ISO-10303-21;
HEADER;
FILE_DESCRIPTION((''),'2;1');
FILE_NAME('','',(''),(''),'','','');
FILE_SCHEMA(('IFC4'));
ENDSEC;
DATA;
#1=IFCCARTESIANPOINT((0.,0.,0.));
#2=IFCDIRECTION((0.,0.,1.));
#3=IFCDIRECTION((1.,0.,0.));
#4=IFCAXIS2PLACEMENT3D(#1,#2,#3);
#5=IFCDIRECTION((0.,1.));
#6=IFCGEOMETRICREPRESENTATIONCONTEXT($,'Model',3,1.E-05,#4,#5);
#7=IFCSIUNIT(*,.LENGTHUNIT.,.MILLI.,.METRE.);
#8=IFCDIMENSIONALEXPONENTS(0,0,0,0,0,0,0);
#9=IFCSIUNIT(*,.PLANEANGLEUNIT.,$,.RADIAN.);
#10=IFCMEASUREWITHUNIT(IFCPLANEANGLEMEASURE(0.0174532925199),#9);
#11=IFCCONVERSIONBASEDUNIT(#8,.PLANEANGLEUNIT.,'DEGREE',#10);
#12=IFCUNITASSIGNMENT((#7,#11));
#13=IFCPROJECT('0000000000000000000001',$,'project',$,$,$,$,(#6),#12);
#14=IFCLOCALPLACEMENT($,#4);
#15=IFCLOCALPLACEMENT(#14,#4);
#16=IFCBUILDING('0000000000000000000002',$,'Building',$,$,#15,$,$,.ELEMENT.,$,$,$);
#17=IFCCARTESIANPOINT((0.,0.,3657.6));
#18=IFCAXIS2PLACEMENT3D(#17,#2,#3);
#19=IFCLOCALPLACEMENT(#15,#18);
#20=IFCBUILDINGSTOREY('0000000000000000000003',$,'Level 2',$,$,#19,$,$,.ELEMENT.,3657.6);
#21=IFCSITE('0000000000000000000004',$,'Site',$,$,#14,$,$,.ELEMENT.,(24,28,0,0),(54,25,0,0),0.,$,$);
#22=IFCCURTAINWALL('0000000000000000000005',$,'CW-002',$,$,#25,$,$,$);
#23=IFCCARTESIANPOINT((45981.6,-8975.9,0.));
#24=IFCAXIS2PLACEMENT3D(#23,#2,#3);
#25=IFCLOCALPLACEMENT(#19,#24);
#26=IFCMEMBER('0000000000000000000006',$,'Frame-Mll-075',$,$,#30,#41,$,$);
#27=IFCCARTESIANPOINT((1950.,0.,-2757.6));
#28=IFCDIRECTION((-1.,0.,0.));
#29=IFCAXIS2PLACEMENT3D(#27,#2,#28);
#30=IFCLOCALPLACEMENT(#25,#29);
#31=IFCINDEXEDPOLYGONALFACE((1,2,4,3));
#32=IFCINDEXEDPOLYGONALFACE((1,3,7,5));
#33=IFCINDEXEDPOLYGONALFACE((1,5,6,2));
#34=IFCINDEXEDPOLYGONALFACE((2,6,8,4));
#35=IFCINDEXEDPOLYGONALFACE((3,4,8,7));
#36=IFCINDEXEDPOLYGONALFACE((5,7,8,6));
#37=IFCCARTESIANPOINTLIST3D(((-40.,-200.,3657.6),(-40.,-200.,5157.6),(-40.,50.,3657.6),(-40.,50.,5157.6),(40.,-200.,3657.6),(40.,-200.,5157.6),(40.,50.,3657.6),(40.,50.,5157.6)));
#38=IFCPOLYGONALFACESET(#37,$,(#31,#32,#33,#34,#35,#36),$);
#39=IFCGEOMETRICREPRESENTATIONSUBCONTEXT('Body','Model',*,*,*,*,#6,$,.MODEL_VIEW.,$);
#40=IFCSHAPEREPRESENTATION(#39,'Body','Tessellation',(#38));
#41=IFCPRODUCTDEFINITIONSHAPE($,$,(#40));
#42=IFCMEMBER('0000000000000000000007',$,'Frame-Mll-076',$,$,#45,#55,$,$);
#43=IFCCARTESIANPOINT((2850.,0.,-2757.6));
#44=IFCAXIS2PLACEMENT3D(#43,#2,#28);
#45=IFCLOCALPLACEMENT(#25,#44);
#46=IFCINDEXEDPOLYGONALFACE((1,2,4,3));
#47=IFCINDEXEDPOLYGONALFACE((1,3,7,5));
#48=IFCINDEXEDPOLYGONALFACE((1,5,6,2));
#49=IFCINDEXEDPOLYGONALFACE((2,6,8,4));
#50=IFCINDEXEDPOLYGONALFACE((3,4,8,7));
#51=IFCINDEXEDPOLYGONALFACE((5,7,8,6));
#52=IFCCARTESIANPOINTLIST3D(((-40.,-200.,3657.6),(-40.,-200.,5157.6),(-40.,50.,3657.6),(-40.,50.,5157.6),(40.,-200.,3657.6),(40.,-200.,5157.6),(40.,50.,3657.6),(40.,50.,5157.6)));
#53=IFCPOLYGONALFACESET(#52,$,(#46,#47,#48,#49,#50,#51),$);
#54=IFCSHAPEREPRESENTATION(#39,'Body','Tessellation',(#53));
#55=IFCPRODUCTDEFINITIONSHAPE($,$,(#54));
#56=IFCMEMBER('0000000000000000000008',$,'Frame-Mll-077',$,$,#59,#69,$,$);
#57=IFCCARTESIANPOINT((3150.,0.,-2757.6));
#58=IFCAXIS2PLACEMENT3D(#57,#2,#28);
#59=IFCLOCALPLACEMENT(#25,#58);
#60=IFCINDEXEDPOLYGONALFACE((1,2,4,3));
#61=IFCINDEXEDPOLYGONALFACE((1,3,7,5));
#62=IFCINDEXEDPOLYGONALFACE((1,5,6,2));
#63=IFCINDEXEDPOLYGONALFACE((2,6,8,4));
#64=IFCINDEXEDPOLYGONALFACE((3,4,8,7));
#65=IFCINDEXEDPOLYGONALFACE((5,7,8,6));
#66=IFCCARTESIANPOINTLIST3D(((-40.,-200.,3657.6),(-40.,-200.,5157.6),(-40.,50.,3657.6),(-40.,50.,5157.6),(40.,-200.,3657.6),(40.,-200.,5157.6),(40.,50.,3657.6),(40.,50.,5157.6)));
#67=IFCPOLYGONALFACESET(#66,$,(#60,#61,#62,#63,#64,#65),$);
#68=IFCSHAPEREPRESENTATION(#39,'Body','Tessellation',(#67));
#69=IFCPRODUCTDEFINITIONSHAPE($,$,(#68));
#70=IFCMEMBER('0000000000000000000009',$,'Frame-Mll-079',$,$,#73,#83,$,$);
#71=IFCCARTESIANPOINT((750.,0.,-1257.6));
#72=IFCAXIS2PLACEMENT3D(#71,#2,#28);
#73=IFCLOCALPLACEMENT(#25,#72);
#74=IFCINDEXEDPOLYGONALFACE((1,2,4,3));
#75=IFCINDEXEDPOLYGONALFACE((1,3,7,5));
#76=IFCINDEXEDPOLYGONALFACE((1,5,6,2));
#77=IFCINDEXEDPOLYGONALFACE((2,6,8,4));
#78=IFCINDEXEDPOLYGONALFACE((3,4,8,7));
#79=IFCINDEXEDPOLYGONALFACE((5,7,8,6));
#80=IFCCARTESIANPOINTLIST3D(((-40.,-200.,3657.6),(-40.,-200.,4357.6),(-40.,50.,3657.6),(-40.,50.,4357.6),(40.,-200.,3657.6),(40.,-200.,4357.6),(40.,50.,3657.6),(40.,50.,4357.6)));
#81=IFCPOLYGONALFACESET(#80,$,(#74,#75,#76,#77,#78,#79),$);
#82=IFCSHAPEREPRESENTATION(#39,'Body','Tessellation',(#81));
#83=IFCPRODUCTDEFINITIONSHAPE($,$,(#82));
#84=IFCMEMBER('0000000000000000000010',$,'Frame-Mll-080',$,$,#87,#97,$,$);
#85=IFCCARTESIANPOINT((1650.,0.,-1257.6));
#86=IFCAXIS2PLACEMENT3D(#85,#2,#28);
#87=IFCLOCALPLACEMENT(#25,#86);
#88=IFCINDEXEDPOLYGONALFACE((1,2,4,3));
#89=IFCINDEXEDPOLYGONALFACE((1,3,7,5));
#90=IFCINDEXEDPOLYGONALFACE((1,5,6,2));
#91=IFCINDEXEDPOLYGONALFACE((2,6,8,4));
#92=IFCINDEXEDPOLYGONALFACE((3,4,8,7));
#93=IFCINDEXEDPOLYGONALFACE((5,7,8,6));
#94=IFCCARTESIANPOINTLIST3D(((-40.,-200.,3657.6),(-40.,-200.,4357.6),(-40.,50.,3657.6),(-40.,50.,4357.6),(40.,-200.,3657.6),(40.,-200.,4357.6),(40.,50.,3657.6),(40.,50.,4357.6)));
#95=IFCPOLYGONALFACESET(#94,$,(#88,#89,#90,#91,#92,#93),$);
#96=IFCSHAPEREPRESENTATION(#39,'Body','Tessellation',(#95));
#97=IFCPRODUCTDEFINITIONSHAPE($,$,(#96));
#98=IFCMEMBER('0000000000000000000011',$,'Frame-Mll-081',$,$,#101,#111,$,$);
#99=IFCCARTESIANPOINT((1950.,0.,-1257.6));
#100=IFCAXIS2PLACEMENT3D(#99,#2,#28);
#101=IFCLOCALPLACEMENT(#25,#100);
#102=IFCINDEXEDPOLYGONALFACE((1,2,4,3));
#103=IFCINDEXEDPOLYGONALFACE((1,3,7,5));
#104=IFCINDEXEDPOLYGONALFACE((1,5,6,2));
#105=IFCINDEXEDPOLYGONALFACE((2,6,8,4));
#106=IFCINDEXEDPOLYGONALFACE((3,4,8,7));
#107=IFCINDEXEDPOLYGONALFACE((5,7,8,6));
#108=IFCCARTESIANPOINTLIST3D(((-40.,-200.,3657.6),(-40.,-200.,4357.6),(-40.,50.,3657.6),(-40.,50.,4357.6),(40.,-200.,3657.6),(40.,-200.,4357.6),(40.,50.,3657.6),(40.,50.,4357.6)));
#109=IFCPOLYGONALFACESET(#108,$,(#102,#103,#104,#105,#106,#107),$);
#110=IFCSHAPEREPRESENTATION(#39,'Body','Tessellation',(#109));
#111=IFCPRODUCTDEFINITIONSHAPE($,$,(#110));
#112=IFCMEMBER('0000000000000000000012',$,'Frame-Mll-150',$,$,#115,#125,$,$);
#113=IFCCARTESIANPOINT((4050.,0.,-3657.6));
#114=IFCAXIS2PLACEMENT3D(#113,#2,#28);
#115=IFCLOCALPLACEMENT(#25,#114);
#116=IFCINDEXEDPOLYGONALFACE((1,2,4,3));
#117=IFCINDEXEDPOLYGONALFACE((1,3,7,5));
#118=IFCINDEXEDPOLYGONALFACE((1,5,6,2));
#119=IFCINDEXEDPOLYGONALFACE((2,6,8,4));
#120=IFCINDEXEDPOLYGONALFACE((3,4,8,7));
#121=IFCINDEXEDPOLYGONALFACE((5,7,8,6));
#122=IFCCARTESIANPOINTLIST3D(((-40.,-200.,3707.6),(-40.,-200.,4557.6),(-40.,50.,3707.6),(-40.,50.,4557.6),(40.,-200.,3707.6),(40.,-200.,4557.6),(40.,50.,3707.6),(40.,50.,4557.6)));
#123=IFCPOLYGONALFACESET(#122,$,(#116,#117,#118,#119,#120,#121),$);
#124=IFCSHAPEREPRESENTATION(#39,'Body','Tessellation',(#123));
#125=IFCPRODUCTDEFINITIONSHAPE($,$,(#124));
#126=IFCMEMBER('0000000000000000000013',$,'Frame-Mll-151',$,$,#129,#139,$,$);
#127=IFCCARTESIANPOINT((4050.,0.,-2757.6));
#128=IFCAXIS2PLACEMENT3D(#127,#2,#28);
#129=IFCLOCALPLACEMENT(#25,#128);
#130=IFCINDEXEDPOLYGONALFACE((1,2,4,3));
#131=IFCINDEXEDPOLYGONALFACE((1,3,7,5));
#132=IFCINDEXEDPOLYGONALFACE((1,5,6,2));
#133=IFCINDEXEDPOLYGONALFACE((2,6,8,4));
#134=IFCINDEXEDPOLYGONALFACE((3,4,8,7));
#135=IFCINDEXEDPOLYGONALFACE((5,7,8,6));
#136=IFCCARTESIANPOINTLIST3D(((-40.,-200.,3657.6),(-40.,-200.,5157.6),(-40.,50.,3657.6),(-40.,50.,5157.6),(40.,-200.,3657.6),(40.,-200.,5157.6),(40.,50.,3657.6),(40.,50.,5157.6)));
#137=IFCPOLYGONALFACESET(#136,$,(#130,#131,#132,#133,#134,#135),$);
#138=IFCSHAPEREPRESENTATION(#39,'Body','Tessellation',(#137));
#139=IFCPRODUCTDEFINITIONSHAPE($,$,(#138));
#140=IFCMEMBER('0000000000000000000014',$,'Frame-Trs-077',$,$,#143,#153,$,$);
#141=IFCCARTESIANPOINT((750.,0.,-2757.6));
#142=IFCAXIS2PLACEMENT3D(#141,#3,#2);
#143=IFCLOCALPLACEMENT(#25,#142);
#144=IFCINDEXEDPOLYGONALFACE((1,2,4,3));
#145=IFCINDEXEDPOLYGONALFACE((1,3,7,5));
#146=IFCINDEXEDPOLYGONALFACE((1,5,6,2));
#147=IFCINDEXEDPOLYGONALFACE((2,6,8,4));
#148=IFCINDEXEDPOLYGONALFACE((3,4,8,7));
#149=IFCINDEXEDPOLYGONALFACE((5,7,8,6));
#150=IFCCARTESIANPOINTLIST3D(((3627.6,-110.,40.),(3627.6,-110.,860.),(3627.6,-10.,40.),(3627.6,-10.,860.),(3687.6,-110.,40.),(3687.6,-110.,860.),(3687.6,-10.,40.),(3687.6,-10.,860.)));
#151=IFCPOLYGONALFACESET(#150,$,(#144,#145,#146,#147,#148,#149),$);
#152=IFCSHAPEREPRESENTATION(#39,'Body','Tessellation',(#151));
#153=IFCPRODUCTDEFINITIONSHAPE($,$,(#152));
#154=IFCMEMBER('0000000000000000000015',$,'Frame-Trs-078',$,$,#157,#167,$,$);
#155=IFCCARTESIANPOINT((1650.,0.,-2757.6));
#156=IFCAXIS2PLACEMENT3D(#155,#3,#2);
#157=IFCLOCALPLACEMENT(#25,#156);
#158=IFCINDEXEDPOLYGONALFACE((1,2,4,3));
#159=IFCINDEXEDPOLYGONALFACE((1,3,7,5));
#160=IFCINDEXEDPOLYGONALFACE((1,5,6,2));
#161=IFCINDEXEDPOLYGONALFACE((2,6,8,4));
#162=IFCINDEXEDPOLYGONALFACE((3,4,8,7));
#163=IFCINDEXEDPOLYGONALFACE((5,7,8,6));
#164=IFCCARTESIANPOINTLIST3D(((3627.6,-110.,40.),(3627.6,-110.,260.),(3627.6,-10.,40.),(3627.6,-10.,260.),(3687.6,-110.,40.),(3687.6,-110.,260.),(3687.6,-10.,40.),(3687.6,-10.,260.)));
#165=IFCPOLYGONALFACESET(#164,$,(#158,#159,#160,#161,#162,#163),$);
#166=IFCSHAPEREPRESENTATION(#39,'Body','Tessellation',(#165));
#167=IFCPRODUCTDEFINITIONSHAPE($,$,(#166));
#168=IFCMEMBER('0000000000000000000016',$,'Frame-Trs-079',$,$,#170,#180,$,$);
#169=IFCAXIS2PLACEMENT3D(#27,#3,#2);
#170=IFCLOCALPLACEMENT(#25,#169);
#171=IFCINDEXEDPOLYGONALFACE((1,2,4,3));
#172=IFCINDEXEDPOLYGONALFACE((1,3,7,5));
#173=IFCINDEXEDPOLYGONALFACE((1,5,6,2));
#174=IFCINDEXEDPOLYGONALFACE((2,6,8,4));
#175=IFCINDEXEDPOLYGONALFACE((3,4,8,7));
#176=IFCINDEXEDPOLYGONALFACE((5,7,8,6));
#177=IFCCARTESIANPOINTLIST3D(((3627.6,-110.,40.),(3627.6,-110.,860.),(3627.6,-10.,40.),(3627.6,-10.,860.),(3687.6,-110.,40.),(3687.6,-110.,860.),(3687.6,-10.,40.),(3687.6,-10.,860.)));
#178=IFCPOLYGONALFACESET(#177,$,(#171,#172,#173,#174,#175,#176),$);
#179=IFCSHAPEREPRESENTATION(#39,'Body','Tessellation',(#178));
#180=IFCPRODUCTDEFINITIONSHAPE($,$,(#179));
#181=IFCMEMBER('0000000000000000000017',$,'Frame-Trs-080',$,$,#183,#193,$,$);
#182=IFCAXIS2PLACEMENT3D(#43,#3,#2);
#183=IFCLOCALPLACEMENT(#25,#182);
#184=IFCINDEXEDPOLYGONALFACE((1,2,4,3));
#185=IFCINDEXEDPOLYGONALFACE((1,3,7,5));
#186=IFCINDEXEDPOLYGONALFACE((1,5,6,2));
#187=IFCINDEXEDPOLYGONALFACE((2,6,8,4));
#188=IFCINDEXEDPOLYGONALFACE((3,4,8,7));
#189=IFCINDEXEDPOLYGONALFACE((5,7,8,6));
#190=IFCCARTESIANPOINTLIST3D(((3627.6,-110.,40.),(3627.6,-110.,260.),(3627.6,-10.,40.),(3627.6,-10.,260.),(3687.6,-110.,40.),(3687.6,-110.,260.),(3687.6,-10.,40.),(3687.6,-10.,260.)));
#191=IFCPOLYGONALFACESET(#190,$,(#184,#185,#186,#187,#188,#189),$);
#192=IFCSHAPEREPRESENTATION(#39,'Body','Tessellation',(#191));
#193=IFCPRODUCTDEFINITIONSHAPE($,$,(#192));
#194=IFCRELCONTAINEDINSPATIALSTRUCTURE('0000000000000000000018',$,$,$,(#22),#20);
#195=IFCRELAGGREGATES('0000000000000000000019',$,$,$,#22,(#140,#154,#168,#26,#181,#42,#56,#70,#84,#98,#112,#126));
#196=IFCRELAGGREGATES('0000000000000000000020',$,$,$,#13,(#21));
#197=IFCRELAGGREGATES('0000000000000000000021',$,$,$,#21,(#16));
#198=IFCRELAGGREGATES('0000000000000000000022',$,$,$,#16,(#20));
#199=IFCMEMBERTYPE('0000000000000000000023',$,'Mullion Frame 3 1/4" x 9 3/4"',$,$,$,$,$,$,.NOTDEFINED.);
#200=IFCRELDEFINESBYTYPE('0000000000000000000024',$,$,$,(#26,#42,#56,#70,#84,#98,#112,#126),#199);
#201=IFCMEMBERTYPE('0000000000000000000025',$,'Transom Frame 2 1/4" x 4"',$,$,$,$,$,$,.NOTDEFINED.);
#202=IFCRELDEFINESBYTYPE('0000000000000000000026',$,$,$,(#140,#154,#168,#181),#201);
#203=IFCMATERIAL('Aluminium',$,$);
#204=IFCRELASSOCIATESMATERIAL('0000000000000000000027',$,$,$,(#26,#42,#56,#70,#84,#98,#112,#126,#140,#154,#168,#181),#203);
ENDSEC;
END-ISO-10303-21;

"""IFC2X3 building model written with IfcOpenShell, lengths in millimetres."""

from ifc_helpers import new_model, entity, si_unit, converted_unit, direction, frame, origin_with_axes, place, context, subcontext, project, spatial, polyline, outline, extrude, material, type_object, element, aggregate, save


model = new_model("IFC2X3")

# Units and contexts
model_context = context("Model", 3, precision=1e-05, world=origin_with_axes(), true_north=direction((0.0, 1.0)))
body_context = subcontext(model_context, "Body", "Model", "MODEL_VIEW")
ifc_project = project(units=[si_unit("LENGTHUNIT", "METRE", prefix="MILLI"), converted_unit("PLANEANGLEUNIT", "DEGREE", entity("IfcPlaneAngleMeasure", 0.0174532925199), si_unit("PLANEANGLEUNIT", "RADIAN"), dimensions=[0, 0, 0, 0, 0, 0, 0])], contexts=[model_context])

# Site, building, storey
site_placement = place(None, origin_with_axes())
site = spatial("IfcSite", under=ifc_project, at=site_placement, Name="Site", CompositionType="ELEMENT", RefLatitude=(24, 28, 0, 0), RefLongitude=(54, 25, 0, 0), RefElevation=0.0)
building_placement = place(site_placement, origin_with_axes())
building = spatial("IfcBuilding", under=site, at=building_placement, Name="Building", CompositionType="ELEMENT")
storey_placement = place(building_placement, frame((0.0, 0.0, 3657.6), z_axis=(0.0, 0.0, 1.0), x_axis=(1.0, 0.0, 0.0)))
storey = spatial("IfcBuildingStorey", under=building, at=storey_placement, Name="Level 2", CompositionType="ELEMENT", Elevation=3657.6)

# Curtain wall, members
curtain_wall_placement = place(storey_placement, frame((45981.6, -8975.9, 0.0), z_axis=(0.0, 0.0, 1.0), x_axis=(1.0, 0.0, 0.0)))
curtain_wall = element("IfcCurtainWall", 1, at=curtain_wall_placement, inside=storey, Name="CW-002")
ifc_material_1 = material(Name="Aluminium")
member_type_1 = type_object("IfcMemberType", Name="Mullion Frame 3 1/4\" x 9 3/4\"", PredefinedType="NOTDEFINED")
member_1_placement = place(curtain_wall_placement, frame((1950.0, 0.0, -2757.6), z_axis=(0.0, 0.0, 1.0), x_axis=(-1.0, 0.0, 0.0)))
member_1 = element("IfcMember", 2, at=member_1_placement, type_object=member_type_1, material=ifc_material_1, Name="Frame-Mll-075", context=body_context, shape_type="SweptSolid", body=[
    extrude(outline(polyline([(-40.0, 200.0), (-40.0, -50.0), (40.0, -50.0), (40.0, 200.0), (-40.0, 200.0)])), frame((0.0, 0.0, 3657.6), z_axis=(0.0, 0.0, 1.0), x_axis=(-1.0, 0.0, 0.0)), (0.0, 0.0, 1.0), 1500.0),
])
member_2_placement = place(curtain_wall_placement, frame((2850.0, 0.0, -2757.6), z_axis=(0.0, 0.0, 1.0), x_axis=(-1.0, 0.0, 0.0)))
member_2 = element("IfcMember", 3, at=member_2_placement, type_object=member_type_1, material=ifc_material_1, Name="Frame-Mll-076", context=body_context, shape_type="SweptSolid", body=[
    extrude(outline(polyline([(-40.0, 200.0), (-40.0, -50.0), (40.0, -50.0), (40.0, 200.0), (-40.0, 200.0)])), frame((0.0, 0.0, 3657.6), z_axis=(0.0, 0.0, 1.0), x_axis=(-1.0, 0.0, 0.0)), (0.0, 0.0, 1.0), 1500.0),
])
member_3_placement = place(curtain_wall_placement, frame((3150.0, 0.0, -2757.6), z_axis=(0.0, 0.0, 1.0), x_axis=(-1.0, 0.0, 0.0)))
member_3 = element("IfcMember", 4, at=member_3_placement, type_object=member_type_1, material=ifc_material_1, Name="Frame-Mll-077", context=body_context, shape_type="SweptSolid", body=[
    extrude(outline(polyline([(-40.0, 200.0), (-40.0, -50.0), (40.0, -50.0), (40.0, 200.0), (-40.0, 200.0)])), frame((0.0, 0.0, 3657.6), z_axis=(0.0, 0.0, 1.0), x_axis=(-1.0, 0.0, 0.0)), (0.0, 0.0, 1.0), 1500.0),
])
member_4_placement = place(curtain_wall_placement, frame((750.0, 0.0, -1257.6), z_axis=(0.0, 0.0, 1.0), x_axis=(-1.0, 0.0, 0.0)))
member_4 = element("IfcMember", 5, at=member_4_placement, type_object=member_type_1, material=ifc_material_1, Name="Frame-Mll-079", context=body_context, shape_type="SweptSolid", body=[
    extrude(outline(polyline([(-40.0, 200.0), (-40.0, -50.0), (40.0, -50.0), (40.0, 200.0), (-40.0, 200.0)])), frame((0.0, 0.0, 3657.6), z_axis=(0.0, 0.0, 1.0), x_axis=(-1.0, 0.0, 0.0)), (0.0, 0.0, 1.0), 700.0),
])
member_5_placement = place(curtain_wall_placement, frame((1650.0, 0.0, -1257.6), z_axis=(0.0, 0.0, 1.0), x_axis=(-1.0, 0.0, 0.0)))
member_5 = element("IfcMember", 6, at=member_5_placement, type_object=member_type_1, material=ifc_material_1, Name="Frame-Mll-080", context=body_context, shape_type="SweptSolid", body=[
    extrude(outline(polyline([(-40.0, 200.0), (-40.0, -50.0), (40.0, -50.0), (40.0, 200.0), (-40.0, 200.0)])), frame((0.0, 0.0, 3657.6), z_axis=(0.0, 0.0, 1.0), x_axis=(-1.0, 0.0, 0.0)), (0.0, 0.0, 1.0), 700.0),
])
member_6_placement = place(curtain_wall_placement, frame((1950.0, 0.0, -1257.6), z_axis=(0.0, 0.0, 1.0), x_axis=(-1.0, 0.0, 0.0)))
member_6 = element("IfcMember", 7, at=member_6_placement, type_object=member_type_1, material=ifc_material_1, Name="Frame-Mll-081", context=body_context, shape_type="SweptSolid", body=[
    extrude(outline(polyline([(-40.0, 200.0), (-40.0, -50.0), (40.0, -50.0), (40.0, 200.0), (-40.0, 200.0)])), frame((0.0, 0.0, 3657.6), z_axis=(0.0, 0.0, 1.0), x_axis=(-1.0, 0.0, 0.0)), (0.0, 0.0, 1.0), 700.0),
])
member_7_placement = place(curtain_wall_placement, frame((4050.0, 0.0, -3657.6), z_axis=(0.0, 0.0, 1.0), x_axis=(-1.0, 0.0, 0.0)))
member_7 = element("IfcMember", 8, at=member_7_placement, type_object=member_type_1, material=ifc_material_1, Name="Frame-Mll-150", context=body_context, shape_type="SweptSolid", body=[
    extrude(outline(polyline([(-40.0, 200.0), (-40.0, -50.0), (40.0, -50.0), (40.0, 200.0), (-40.0, 200.0)])), frame((0.0, 0.0, 3707.6), z_axis=(0.0, 0.0, 1.0), x_axis=(-1.0, 0.0, 0.0)), (0.0, 0.0, 1.0), 850.0),
])
member_8_placement = place(curtain_wall_placement, frame((4050.0, 0.0, -2757.6), z_axis=(0.0, 0.0, 1.0), x_axis=(-1.0, 0.0, 0.0)))
member_8 = element("IfcMember", 9, at=member_8_placement, type_object=member_type_1, material=ifc_material_1, Name="Frame-Mll-151", context=body_context, shape_type="SweptSolid", body=[
    extrude(outline(polyline([(-40.0, 200.0), (-40.0, -50.0), (40.0, -50.0), (40.0, 200.0), (-40.0, 200.0)])), frame((0.0, 0.0, 3657.6), z_axis=(0.0, 0.0, 1.0), x_axis=(-1.0, 0.0, 0.0)), (0.0, 0.0, 1.0), 1500.0),
])
member_type_2 = type_object("IfcMemberType", Name="Transom Frame 2 1/4\" x 4\"", PredefinedType="NOTDEFINED")
member_9_placement = place(curtain_wall_placement, frame((750.0, 0.0, -2757.6), z_axis=(1.0, 0.0, 0.0), x_axis=(0.0, 0.0, 1.0)))
member_9 = element("IfcMember", 10, at=member_9_placement, type_object=member_type_2, material=ifc_material_1, Name="Frame-Trs-077", context=body_context, shape_type="SweptSolid", body=[
    extrude(outline(polyline([(-110.0, -3687.6), (-10.0, -3687.6), (-10.0, -3627.6), (-110.0, -3627.6), (-110.0, -3687.6)])), frame((0.0, 0.0, 40.0), z_axis=(0.0, 0.0, 1.0), x_axis=(0.0, 1.0, 0.0)), (0.0, 0.0, 1.0), 820.0),
])
member_10_placement = place(curtain_wall_placement, frame((1650.0, 0.0, -2757.6), z_axis=(1.0, 0.0, 0.0), x_axis=(0.0, 0.0, 1.0)))
member_10 = element("IfcMember", 11, at=member_10_placement, type_object=member_type_2, material=ifc_material_1, Name="Frame-Trs-078", context=body_context, shape_type="SweptSolid", body=[
    extrude(outline(polyline([(-110.0, -3687.6), (-10.0, -3687.6), (-10.0, -3627.6), (-110.0, -3627.6), (-110.0, -3687.6)])), frame((0.0, 0.0, 40.0), z_axis=(0.0, 0.0, 1.0), x_axis=(0.0, 1.0, 0.0)), (0.0, 0.0, 1.0), 220.0),
])
member_11_placement = place(curtain_wall_placement, frame((1950.0, 0.0, -2757.6), z_axis=(1.0, 0.0, 0.0), x_axis=(0.0, 0.0, 1.0)))
member_11 = element("IfcMember", 12, at=member_11_placement, type_object=member_type_2, material=ifc_material_1, Name="Frame-Trs-079", context=body_context, shape_type="SweptSolid", body=[
    extrude(outline(polyline([(-110.0, -3687.6), (-10.0, -3687.6), (-10.0, -3627.6), (-110.0, -3627.6), (-110.0, -3687.6)])), frame((0.0, 0.0, 40.0), z_axis=(0.0, 0.0, 1.0), x_axis=(0.0, 1.0, 0.0)), (0.0, 0.0, 1.0), 820.0),
])
member_12_placement = place(curtain_wall_placement, frame((2850.0, 0.0, -2757.6), z_axis=(1.0, 0.0, 0.0), x_axis=(0.0, 0.0, 1.0)))
member_12 = element("IfcMember", 13, at=member_12_placement, type_object=member_type_2, material=ifc_material_1, Name="Frame-Trs-080", context=body_context, shape_type="SweptSolid", body=[
    extrude(outline(polyline([(-110.0, -3687.6), (-10.0, -3687.6), (-10.0, -3627.6), (-110.0, -3627.6), (-110.0, -3687.6)])), frame((0.0, 0.0, 40.0), z_axis=(0.0, 0.0, 1.0), x_axis=(0.0, 1.0, 0.0)), (0.0, 0.0, 1.0), 220.0),
])
aggregate(curtain_wall, [member_9, member_10, member_11, member_1, member_12, member_2, member_3, member_4, member_5, member_6, member_7, member_8])

save(model, "model.ifc")
